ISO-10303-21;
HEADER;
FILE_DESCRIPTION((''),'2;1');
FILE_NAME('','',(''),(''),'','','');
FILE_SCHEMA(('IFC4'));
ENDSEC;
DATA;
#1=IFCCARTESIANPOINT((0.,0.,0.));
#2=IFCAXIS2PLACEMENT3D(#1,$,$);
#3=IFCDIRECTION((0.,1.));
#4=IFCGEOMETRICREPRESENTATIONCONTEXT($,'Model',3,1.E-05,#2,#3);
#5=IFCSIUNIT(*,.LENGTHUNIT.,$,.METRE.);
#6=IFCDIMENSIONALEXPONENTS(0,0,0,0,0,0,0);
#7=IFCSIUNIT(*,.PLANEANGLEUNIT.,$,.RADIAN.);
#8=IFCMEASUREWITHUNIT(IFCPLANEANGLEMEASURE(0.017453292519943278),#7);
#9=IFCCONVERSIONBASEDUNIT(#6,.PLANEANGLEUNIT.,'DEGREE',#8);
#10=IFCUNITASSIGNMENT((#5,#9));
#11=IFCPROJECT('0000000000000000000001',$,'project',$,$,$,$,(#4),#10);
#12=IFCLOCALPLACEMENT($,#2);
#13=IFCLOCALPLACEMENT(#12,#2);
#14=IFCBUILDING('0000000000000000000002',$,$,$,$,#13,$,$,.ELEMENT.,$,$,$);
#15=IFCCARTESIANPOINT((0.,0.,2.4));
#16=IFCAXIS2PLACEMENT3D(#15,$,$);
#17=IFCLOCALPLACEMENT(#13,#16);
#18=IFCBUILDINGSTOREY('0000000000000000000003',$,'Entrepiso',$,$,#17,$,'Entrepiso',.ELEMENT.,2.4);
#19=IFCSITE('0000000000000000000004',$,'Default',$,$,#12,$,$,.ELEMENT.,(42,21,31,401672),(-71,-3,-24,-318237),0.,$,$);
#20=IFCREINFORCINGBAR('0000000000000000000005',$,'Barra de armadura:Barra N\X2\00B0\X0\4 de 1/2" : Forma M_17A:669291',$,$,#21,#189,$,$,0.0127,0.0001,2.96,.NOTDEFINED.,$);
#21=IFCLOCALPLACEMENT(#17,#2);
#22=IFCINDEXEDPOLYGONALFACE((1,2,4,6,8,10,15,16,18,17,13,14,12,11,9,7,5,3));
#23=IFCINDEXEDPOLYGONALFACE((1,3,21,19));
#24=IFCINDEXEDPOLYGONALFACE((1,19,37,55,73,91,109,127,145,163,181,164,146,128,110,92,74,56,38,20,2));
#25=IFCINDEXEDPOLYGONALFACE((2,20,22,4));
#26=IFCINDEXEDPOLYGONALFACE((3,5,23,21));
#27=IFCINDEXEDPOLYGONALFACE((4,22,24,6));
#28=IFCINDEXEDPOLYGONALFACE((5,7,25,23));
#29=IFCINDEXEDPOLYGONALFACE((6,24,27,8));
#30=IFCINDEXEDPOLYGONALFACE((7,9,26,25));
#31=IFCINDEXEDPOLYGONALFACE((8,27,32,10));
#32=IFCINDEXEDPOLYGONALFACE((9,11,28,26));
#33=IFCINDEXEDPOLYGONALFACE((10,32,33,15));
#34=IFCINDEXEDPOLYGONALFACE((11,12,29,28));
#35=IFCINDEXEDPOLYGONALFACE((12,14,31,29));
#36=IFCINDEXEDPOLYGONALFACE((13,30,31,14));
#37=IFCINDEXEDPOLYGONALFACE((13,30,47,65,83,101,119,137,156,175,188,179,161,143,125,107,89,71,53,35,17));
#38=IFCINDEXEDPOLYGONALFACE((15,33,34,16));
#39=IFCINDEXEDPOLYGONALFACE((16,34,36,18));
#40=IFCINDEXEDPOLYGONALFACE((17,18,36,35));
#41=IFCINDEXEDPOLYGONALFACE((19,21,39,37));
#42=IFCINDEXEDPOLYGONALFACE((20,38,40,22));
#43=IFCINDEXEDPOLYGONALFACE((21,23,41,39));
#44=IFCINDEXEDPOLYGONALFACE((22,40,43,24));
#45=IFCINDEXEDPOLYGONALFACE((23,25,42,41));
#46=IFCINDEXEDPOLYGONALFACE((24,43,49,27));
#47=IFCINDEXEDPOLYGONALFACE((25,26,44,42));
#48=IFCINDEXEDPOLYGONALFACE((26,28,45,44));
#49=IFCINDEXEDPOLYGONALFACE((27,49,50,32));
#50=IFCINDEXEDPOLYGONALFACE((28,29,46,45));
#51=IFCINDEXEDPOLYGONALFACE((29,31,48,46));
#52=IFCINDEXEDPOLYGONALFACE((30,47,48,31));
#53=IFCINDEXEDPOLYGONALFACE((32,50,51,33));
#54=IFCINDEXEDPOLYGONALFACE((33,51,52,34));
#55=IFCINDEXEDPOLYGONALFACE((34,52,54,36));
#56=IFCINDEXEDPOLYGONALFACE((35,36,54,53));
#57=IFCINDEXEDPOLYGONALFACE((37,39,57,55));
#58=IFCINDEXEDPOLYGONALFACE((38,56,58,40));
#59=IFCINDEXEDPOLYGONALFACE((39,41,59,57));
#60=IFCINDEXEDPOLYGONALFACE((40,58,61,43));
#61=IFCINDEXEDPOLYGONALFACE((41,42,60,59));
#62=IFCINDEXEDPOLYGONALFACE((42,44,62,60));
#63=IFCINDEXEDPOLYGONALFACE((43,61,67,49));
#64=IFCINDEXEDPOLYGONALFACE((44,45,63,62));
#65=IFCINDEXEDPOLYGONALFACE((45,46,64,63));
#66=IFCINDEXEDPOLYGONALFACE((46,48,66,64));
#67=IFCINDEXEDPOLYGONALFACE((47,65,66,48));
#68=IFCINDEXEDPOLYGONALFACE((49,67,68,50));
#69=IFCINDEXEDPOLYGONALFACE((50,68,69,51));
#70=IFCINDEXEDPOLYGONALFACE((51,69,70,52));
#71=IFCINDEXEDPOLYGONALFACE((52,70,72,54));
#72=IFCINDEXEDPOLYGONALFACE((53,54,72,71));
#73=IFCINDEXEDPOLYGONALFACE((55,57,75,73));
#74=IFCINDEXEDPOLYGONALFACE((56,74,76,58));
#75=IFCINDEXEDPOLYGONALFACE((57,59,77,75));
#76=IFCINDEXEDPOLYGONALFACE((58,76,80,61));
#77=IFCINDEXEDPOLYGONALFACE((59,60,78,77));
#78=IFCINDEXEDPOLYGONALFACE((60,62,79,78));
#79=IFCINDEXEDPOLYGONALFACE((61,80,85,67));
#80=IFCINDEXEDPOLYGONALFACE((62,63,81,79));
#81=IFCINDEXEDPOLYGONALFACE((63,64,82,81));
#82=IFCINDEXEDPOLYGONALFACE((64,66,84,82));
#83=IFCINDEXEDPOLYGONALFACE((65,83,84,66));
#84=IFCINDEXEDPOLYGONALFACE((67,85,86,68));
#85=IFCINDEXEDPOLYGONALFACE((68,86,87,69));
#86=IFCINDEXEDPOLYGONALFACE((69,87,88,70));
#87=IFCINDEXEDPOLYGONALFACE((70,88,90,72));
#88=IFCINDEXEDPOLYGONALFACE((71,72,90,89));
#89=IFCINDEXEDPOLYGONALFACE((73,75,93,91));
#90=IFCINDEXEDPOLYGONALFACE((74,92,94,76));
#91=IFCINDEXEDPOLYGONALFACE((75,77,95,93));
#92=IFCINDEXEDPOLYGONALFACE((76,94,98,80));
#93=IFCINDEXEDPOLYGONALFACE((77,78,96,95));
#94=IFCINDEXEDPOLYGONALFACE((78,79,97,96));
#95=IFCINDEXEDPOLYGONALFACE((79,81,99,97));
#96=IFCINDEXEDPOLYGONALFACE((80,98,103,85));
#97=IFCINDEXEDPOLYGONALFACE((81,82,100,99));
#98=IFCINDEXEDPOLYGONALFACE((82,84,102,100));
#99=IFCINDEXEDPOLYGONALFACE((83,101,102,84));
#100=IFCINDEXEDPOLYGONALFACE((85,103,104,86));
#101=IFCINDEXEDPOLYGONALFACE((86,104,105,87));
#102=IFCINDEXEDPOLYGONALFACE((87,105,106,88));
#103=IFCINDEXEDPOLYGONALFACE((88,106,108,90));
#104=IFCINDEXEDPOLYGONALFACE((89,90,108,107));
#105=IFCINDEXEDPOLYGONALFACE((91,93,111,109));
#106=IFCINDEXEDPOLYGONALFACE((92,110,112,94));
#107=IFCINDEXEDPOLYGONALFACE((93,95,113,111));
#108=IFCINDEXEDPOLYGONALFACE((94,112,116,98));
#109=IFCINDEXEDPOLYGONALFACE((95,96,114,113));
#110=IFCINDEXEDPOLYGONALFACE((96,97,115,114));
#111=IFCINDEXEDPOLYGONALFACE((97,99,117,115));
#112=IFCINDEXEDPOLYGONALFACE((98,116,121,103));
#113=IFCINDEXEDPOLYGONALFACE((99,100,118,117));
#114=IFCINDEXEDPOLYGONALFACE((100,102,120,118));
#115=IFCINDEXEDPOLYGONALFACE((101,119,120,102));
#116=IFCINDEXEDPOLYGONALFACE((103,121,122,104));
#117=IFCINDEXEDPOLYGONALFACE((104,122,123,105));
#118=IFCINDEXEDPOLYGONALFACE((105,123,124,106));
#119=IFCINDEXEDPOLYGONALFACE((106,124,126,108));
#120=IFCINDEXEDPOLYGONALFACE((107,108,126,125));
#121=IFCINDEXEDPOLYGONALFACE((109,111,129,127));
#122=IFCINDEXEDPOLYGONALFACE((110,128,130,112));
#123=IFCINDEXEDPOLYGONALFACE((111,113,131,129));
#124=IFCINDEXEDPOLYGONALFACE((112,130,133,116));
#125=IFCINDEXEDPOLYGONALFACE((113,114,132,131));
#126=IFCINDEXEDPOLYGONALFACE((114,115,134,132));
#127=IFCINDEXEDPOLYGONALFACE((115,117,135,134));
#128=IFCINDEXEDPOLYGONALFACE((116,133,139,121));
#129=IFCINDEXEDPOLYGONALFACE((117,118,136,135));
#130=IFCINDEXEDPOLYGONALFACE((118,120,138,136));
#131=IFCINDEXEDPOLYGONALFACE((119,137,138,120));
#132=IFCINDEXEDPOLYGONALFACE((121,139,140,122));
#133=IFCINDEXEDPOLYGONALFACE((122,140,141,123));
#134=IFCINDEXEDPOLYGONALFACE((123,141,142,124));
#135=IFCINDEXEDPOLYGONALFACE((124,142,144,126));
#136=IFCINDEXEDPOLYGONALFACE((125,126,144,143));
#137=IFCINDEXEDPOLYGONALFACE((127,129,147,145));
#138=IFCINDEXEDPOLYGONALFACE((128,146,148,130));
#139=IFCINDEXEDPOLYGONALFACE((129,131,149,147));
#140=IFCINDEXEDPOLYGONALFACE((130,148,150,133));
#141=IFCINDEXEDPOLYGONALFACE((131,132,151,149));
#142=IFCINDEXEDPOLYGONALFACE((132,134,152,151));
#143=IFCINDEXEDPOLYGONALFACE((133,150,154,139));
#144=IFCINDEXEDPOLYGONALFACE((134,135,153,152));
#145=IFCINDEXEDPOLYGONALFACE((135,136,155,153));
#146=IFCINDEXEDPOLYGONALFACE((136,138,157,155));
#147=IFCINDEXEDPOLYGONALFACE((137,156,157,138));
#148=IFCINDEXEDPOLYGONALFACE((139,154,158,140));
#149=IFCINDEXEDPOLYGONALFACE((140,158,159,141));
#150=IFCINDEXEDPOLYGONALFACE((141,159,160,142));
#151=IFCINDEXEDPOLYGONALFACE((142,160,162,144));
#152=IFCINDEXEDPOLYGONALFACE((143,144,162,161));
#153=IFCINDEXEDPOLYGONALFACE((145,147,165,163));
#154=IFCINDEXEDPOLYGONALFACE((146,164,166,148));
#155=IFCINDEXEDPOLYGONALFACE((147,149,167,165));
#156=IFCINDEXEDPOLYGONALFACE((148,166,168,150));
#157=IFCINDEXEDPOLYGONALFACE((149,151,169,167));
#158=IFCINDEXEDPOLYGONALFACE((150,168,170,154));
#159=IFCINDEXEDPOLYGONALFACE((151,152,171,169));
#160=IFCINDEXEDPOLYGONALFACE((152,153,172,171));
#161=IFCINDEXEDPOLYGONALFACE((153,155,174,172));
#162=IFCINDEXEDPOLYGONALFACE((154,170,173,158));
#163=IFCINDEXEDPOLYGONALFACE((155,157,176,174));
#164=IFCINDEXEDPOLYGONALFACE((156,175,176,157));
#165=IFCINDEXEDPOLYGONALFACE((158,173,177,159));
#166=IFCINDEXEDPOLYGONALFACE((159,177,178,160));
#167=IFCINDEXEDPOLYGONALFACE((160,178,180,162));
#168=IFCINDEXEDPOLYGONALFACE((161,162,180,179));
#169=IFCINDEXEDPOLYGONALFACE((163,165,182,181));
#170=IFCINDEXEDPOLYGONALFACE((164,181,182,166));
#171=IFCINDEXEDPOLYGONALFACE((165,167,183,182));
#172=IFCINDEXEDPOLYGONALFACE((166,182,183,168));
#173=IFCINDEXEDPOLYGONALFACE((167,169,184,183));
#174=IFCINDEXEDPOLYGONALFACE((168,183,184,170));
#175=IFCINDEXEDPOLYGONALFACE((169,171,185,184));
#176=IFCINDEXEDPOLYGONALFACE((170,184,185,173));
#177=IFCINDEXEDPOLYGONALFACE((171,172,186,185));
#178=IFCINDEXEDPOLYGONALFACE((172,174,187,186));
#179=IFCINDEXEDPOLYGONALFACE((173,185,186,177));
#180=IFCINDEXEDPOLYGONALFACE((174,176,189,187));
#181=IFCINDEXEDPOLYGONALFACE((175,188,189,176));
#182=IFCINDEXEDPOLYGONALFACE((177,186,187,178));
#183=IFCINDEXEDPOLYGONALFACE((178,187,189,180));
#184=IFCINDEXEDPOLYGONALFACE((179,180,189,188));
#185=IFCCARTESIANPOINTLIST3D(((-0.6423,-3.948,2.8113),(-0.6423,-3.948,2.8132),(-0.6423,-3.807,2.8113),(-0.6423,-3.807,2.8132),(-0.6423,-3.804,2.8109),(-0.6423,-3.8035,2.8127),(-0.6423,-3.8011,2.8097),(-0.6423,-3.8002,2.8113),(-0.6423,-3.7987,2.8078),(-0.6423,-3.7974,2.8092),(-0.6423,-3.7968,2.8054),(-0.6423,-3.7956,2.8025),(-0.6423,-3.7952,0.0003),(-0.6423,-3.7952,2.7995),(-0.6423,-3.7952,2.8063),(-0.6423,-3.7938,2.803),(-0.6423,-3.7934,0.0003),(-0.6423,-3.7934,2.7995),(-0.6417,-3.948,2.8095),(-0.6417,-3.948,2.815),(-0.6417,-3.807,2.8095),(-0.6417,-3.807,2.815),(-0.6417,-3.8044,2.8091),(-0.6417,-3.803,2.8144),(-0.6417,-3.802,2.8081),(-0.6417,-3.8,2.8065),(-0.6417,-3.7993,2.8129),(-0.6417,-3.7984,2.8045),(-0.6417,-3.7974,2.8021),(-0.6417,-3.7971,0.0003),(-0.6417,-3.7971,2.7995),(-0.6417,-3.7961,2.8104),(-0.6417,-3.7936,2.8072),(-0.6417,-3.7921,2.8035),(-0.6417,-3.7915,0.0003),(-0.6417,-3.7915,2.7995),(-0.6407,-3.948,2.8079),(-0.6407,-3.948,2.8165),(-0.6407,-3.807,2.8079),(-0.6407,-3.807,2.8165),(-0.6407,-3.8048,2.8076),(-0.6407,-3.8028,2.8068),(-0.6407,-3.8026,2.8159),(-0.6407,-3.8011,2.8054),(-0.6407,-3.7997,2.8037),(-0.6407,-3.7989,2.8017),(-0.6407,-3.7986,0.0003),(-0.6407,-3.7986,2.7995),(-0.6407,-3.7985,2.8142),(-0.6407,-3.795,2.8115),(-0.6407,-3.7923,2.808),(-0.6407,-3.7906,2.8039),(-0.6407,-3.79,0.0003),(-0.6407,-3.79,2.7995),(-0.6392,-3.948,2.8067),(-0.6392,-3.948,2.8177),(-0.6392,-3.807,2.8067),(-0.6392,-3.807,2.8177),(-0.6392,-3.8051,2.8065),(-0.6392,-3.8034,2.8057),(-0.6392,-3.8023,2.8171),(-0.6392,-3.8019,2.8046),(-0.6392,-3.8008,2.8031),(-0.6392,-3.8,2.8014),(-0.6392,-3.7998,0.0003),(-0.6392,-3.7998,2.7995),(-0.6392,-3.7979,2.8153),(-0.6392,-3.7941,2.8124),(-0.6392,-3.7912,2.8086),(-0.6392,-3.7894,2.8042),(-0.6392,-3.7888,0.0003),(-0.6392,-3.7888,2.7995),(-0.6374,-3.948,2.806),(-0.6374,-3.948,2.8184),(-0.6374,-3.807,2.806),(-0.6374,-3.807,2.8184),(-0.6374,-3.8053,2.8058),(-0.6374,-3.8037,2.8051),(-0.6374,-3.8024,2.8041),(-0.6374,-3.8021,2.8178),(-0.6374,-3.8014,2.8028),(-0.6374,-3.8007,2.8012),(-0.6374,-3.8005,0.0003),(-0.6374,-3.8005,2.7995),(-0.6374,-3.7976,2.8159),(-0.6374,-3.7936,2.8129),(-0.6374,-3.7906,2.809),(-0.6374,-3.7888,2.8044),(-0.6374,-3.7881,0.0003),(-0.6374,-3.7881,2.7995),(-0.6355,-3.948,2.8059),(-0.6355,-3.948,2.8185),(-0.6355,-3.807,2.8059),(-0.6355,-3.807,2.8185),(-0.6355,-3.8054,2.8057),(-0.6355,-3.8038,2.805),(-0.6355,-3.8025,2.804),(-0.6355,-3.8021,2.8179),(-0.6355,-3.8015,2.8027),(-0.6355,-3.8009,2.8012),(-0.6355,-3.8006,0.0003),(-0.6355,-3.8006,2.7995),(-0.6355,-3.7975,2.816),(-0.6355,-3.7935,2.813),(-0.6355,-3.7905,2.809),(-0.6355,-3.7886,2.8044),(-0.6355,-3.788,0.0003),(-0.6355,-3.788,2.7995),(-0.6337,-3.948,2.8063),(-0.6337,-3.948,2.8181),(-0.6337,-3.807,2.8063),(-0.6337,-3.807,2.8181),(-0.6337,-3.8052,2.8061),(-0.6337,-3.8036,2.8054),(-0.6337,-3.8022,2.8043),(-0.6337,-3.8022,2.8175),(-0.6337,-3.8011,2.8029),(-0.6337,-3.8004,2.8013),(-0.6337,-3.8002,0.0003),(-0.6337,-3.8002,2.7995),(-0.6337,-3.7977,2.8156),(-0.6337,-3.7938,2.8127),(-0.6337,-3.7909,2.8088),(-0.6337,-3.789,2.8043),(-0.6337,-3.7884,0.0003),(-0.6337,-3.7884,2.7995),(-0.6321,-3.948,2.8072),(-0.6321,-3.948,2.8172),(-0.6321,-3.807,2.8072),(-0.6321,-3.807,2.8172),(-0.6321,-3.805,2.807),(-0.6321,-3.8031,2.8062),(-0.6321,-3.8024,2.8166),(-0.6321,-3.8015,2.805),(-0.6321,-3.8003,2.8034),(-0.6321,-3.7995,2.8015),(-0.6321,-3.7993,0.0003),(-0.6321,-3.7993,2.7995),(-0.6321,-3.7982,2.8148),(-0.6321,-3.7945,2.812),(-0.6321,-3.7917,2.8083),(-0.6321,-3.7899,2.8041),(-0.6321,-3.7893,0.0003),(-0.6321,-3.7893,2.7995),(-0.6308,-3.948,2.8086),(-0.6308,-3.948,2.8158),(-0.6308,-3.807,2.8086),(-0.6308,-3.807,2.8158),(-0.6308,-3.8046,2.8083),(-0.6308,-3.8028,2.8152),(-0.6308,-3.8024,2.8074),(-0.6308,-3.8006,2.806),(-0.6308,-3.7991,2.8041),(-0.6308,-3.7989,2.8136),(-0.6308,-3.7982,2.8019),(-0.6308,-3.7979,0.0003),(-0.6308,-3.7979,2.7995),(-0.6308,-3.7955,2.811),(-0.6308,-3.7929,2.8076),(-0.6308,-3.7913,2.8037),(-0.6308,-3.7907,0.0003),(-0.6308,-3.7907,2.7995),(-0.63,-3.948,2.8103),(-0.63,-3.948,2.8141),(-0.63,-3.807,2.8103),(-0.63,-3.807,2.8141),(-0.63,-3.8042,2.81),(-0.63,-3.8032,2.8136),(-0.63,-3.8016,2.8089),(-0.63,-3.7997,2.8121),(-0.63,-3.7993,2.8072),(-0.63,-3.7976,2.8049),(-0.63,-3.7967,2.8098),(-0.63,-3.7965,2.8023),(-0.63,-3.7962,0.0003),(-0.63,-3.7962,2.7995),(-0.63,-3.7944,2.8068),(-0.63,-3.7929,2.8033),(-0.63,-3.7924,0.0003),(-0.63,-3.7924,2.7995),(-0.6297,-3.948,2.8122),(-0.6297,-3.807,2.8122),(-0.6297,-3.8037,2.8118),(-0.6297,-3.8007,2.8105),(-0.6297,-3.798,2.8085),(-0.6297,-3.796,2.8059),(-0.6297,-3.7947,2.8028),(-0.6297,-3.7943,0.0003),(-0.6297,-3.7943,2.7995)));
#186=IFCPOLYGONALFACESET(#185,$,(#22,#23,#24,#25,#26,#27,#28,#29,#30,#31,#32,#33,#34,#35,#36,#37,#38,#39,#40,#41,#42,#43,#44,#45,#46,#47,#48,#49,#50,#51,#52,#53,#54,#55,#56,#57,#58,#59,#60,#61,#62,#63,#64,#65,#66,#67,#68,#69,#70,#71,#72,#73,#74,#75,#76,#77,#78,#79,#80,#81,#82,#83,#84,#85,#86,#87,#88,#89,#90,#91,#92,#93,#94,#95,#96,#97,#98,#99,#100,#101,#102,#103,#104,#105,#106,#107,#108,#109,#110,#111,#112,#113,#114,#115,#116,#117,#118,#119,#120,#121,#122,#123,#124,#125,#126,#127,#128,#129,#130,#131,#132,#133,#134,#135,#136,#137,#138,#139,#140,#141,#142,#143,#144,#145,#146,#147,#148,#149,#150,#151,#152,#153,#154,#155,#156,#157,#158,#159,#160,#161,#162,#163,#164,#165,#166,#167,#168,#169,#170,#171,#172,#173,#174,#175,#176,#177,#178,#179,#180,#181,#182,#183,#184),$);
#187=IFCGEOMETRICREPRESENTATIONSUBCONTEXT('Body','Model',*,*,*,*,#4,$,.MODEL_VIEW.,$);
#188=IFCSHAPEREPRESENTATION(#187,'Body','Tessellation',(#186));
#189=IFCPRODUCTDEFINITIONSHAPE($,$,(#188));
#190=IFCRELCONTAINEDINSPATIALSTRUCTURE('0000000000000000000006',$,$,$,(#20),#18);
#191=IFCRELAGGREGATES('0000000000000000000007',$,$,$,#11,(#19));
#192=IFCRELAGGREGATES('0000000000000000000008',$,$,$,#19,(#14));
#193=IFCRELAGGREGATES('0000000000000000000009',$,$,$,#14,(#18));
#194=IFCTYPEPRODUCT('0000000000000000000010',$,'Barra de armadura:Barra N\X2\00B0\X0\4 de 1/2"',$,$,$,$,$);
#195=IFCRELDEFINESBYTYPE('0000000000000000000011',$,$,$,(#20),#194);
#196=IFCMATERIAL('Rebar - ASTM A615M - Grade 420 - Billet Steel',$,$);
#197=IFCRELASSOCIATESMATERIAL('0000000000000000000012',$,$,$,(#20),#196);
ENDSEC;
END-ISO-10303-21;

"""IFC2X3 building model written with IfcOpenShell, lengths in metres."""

from ifc_helpers import new_model, entity, si_unit, converted_unit, direction, frame, origin, place, context, subcontext, project, spatial, material, type_object, element, save


model = new_model("IFC2X3")

# Units and contexts
model_context = context("Model", 3, precision=1e-05, world=origin(), true_north=direction((0.0, 1.0)))
body_context = subcontext(model_context, "Body", "Model", "MODEL_VIEW")
ifc_project = project(units=[si_unit("LENGTHUNIT", "METRE"), converted_unit("PLANEANGLEUNIT", "DEGREE", entity("IfcPlaneAngleMeasure", 0.017453292519943278), si_unit("PLANEANGLEUNIT", "RADIAN"), dimensions=[0, 0, 0, 0, 0, 0, 0])], contexts=[model_context])

# Site, building, storey
site_placement = place(None, origin())
site = spatial("IfcSite", under=ifc_project, at=site_placement, Name="Default", CompositionType="ELEMENT", RefLatitude=(42, 21, 31, 401672), RefLongitude=(-71, -3, -24, -318237), RefElevation=0.0)
building_placement = place(site_placement, origin())
building = spatial("IfcBuilding", under=site, at=building_placement, CompositionType="ELEMENT")
storey_placement = place(building_placement, frame((0.0, 0.0, 2.4)))
storey = spatial("IfcBuildingStorey", under=building, at=storey_placement, Name="Entrepiso", LongName="Entrepiso", CompositionType="ELEMENT", Elevation=2.4)

# Reinforcing bar
ifc_material = material(Name="Rebar - ASTM A615M - Grade 420 - Billet Steel")
type_product_1 = type_object("IfcTypeProduct", Name="Barra de armadura:Barra N°4 de 1/2\"")
reinforcing_bar_1_placement = place(storey_placement, origin())
element("IfcReinforcingBar", 1, at=reinforcing_bar_1_placement, inside=storey, type_object=type_product_1, material=ifc_material, Name="Barra de armadura:Barra N°4 de 1/2\" : Forma M_17A:669291", BarLength=2.96, BarRole="NOTDEFINED", CrossSectionArea=0.0001, NominalDiameter=0.0127, context=body_context, shape_type="AdvancedSweptSolid", body=[
    entity("IfcSweptDiskSolid", entity("IfcCompositeCurve", [entity("IfcCompositeCurveSegment", "CONTINUOUS", True, entity("IfcPolyline", [entity("IfcCartesianPoint", [-0.636, -3.7943, 0.0003]), entity("IfcCartesianPoint", [-0.636, -3.7943, 2.7995])])), entity("IfcCompositeCurveSegment", "CONTINUOUS", True, entity("IfcTrimmedCurve", entity("IfcCircle", entity("IfcAxis2Placement3D", entity("IfcCartesianPoint", [-0.636, -3.807, 2.7995]), entity("IfcDirection", [1.0, 0.0, 0.0]), entity("IfcDirection", [0.0, 0.0, 1.0])), 0.0127), [entity("IfcParameterValue", 270.0)], [entity("IfcParameterValue", 360.0)], True, "PARAMETER")), entity("IfcCompositeCurveSegment", "CONTINUOUS", True, entity("IfcPolyline", [entity("IfcCartesianPoint", [-0.636, -3.807, 2.8122]), entity("IfcCartesianPoint", [-0.636, -3.948, 2.8122])]))], False), 0.0063, None, 0.0, 92.0),
])

save(model, "model.ifc")
